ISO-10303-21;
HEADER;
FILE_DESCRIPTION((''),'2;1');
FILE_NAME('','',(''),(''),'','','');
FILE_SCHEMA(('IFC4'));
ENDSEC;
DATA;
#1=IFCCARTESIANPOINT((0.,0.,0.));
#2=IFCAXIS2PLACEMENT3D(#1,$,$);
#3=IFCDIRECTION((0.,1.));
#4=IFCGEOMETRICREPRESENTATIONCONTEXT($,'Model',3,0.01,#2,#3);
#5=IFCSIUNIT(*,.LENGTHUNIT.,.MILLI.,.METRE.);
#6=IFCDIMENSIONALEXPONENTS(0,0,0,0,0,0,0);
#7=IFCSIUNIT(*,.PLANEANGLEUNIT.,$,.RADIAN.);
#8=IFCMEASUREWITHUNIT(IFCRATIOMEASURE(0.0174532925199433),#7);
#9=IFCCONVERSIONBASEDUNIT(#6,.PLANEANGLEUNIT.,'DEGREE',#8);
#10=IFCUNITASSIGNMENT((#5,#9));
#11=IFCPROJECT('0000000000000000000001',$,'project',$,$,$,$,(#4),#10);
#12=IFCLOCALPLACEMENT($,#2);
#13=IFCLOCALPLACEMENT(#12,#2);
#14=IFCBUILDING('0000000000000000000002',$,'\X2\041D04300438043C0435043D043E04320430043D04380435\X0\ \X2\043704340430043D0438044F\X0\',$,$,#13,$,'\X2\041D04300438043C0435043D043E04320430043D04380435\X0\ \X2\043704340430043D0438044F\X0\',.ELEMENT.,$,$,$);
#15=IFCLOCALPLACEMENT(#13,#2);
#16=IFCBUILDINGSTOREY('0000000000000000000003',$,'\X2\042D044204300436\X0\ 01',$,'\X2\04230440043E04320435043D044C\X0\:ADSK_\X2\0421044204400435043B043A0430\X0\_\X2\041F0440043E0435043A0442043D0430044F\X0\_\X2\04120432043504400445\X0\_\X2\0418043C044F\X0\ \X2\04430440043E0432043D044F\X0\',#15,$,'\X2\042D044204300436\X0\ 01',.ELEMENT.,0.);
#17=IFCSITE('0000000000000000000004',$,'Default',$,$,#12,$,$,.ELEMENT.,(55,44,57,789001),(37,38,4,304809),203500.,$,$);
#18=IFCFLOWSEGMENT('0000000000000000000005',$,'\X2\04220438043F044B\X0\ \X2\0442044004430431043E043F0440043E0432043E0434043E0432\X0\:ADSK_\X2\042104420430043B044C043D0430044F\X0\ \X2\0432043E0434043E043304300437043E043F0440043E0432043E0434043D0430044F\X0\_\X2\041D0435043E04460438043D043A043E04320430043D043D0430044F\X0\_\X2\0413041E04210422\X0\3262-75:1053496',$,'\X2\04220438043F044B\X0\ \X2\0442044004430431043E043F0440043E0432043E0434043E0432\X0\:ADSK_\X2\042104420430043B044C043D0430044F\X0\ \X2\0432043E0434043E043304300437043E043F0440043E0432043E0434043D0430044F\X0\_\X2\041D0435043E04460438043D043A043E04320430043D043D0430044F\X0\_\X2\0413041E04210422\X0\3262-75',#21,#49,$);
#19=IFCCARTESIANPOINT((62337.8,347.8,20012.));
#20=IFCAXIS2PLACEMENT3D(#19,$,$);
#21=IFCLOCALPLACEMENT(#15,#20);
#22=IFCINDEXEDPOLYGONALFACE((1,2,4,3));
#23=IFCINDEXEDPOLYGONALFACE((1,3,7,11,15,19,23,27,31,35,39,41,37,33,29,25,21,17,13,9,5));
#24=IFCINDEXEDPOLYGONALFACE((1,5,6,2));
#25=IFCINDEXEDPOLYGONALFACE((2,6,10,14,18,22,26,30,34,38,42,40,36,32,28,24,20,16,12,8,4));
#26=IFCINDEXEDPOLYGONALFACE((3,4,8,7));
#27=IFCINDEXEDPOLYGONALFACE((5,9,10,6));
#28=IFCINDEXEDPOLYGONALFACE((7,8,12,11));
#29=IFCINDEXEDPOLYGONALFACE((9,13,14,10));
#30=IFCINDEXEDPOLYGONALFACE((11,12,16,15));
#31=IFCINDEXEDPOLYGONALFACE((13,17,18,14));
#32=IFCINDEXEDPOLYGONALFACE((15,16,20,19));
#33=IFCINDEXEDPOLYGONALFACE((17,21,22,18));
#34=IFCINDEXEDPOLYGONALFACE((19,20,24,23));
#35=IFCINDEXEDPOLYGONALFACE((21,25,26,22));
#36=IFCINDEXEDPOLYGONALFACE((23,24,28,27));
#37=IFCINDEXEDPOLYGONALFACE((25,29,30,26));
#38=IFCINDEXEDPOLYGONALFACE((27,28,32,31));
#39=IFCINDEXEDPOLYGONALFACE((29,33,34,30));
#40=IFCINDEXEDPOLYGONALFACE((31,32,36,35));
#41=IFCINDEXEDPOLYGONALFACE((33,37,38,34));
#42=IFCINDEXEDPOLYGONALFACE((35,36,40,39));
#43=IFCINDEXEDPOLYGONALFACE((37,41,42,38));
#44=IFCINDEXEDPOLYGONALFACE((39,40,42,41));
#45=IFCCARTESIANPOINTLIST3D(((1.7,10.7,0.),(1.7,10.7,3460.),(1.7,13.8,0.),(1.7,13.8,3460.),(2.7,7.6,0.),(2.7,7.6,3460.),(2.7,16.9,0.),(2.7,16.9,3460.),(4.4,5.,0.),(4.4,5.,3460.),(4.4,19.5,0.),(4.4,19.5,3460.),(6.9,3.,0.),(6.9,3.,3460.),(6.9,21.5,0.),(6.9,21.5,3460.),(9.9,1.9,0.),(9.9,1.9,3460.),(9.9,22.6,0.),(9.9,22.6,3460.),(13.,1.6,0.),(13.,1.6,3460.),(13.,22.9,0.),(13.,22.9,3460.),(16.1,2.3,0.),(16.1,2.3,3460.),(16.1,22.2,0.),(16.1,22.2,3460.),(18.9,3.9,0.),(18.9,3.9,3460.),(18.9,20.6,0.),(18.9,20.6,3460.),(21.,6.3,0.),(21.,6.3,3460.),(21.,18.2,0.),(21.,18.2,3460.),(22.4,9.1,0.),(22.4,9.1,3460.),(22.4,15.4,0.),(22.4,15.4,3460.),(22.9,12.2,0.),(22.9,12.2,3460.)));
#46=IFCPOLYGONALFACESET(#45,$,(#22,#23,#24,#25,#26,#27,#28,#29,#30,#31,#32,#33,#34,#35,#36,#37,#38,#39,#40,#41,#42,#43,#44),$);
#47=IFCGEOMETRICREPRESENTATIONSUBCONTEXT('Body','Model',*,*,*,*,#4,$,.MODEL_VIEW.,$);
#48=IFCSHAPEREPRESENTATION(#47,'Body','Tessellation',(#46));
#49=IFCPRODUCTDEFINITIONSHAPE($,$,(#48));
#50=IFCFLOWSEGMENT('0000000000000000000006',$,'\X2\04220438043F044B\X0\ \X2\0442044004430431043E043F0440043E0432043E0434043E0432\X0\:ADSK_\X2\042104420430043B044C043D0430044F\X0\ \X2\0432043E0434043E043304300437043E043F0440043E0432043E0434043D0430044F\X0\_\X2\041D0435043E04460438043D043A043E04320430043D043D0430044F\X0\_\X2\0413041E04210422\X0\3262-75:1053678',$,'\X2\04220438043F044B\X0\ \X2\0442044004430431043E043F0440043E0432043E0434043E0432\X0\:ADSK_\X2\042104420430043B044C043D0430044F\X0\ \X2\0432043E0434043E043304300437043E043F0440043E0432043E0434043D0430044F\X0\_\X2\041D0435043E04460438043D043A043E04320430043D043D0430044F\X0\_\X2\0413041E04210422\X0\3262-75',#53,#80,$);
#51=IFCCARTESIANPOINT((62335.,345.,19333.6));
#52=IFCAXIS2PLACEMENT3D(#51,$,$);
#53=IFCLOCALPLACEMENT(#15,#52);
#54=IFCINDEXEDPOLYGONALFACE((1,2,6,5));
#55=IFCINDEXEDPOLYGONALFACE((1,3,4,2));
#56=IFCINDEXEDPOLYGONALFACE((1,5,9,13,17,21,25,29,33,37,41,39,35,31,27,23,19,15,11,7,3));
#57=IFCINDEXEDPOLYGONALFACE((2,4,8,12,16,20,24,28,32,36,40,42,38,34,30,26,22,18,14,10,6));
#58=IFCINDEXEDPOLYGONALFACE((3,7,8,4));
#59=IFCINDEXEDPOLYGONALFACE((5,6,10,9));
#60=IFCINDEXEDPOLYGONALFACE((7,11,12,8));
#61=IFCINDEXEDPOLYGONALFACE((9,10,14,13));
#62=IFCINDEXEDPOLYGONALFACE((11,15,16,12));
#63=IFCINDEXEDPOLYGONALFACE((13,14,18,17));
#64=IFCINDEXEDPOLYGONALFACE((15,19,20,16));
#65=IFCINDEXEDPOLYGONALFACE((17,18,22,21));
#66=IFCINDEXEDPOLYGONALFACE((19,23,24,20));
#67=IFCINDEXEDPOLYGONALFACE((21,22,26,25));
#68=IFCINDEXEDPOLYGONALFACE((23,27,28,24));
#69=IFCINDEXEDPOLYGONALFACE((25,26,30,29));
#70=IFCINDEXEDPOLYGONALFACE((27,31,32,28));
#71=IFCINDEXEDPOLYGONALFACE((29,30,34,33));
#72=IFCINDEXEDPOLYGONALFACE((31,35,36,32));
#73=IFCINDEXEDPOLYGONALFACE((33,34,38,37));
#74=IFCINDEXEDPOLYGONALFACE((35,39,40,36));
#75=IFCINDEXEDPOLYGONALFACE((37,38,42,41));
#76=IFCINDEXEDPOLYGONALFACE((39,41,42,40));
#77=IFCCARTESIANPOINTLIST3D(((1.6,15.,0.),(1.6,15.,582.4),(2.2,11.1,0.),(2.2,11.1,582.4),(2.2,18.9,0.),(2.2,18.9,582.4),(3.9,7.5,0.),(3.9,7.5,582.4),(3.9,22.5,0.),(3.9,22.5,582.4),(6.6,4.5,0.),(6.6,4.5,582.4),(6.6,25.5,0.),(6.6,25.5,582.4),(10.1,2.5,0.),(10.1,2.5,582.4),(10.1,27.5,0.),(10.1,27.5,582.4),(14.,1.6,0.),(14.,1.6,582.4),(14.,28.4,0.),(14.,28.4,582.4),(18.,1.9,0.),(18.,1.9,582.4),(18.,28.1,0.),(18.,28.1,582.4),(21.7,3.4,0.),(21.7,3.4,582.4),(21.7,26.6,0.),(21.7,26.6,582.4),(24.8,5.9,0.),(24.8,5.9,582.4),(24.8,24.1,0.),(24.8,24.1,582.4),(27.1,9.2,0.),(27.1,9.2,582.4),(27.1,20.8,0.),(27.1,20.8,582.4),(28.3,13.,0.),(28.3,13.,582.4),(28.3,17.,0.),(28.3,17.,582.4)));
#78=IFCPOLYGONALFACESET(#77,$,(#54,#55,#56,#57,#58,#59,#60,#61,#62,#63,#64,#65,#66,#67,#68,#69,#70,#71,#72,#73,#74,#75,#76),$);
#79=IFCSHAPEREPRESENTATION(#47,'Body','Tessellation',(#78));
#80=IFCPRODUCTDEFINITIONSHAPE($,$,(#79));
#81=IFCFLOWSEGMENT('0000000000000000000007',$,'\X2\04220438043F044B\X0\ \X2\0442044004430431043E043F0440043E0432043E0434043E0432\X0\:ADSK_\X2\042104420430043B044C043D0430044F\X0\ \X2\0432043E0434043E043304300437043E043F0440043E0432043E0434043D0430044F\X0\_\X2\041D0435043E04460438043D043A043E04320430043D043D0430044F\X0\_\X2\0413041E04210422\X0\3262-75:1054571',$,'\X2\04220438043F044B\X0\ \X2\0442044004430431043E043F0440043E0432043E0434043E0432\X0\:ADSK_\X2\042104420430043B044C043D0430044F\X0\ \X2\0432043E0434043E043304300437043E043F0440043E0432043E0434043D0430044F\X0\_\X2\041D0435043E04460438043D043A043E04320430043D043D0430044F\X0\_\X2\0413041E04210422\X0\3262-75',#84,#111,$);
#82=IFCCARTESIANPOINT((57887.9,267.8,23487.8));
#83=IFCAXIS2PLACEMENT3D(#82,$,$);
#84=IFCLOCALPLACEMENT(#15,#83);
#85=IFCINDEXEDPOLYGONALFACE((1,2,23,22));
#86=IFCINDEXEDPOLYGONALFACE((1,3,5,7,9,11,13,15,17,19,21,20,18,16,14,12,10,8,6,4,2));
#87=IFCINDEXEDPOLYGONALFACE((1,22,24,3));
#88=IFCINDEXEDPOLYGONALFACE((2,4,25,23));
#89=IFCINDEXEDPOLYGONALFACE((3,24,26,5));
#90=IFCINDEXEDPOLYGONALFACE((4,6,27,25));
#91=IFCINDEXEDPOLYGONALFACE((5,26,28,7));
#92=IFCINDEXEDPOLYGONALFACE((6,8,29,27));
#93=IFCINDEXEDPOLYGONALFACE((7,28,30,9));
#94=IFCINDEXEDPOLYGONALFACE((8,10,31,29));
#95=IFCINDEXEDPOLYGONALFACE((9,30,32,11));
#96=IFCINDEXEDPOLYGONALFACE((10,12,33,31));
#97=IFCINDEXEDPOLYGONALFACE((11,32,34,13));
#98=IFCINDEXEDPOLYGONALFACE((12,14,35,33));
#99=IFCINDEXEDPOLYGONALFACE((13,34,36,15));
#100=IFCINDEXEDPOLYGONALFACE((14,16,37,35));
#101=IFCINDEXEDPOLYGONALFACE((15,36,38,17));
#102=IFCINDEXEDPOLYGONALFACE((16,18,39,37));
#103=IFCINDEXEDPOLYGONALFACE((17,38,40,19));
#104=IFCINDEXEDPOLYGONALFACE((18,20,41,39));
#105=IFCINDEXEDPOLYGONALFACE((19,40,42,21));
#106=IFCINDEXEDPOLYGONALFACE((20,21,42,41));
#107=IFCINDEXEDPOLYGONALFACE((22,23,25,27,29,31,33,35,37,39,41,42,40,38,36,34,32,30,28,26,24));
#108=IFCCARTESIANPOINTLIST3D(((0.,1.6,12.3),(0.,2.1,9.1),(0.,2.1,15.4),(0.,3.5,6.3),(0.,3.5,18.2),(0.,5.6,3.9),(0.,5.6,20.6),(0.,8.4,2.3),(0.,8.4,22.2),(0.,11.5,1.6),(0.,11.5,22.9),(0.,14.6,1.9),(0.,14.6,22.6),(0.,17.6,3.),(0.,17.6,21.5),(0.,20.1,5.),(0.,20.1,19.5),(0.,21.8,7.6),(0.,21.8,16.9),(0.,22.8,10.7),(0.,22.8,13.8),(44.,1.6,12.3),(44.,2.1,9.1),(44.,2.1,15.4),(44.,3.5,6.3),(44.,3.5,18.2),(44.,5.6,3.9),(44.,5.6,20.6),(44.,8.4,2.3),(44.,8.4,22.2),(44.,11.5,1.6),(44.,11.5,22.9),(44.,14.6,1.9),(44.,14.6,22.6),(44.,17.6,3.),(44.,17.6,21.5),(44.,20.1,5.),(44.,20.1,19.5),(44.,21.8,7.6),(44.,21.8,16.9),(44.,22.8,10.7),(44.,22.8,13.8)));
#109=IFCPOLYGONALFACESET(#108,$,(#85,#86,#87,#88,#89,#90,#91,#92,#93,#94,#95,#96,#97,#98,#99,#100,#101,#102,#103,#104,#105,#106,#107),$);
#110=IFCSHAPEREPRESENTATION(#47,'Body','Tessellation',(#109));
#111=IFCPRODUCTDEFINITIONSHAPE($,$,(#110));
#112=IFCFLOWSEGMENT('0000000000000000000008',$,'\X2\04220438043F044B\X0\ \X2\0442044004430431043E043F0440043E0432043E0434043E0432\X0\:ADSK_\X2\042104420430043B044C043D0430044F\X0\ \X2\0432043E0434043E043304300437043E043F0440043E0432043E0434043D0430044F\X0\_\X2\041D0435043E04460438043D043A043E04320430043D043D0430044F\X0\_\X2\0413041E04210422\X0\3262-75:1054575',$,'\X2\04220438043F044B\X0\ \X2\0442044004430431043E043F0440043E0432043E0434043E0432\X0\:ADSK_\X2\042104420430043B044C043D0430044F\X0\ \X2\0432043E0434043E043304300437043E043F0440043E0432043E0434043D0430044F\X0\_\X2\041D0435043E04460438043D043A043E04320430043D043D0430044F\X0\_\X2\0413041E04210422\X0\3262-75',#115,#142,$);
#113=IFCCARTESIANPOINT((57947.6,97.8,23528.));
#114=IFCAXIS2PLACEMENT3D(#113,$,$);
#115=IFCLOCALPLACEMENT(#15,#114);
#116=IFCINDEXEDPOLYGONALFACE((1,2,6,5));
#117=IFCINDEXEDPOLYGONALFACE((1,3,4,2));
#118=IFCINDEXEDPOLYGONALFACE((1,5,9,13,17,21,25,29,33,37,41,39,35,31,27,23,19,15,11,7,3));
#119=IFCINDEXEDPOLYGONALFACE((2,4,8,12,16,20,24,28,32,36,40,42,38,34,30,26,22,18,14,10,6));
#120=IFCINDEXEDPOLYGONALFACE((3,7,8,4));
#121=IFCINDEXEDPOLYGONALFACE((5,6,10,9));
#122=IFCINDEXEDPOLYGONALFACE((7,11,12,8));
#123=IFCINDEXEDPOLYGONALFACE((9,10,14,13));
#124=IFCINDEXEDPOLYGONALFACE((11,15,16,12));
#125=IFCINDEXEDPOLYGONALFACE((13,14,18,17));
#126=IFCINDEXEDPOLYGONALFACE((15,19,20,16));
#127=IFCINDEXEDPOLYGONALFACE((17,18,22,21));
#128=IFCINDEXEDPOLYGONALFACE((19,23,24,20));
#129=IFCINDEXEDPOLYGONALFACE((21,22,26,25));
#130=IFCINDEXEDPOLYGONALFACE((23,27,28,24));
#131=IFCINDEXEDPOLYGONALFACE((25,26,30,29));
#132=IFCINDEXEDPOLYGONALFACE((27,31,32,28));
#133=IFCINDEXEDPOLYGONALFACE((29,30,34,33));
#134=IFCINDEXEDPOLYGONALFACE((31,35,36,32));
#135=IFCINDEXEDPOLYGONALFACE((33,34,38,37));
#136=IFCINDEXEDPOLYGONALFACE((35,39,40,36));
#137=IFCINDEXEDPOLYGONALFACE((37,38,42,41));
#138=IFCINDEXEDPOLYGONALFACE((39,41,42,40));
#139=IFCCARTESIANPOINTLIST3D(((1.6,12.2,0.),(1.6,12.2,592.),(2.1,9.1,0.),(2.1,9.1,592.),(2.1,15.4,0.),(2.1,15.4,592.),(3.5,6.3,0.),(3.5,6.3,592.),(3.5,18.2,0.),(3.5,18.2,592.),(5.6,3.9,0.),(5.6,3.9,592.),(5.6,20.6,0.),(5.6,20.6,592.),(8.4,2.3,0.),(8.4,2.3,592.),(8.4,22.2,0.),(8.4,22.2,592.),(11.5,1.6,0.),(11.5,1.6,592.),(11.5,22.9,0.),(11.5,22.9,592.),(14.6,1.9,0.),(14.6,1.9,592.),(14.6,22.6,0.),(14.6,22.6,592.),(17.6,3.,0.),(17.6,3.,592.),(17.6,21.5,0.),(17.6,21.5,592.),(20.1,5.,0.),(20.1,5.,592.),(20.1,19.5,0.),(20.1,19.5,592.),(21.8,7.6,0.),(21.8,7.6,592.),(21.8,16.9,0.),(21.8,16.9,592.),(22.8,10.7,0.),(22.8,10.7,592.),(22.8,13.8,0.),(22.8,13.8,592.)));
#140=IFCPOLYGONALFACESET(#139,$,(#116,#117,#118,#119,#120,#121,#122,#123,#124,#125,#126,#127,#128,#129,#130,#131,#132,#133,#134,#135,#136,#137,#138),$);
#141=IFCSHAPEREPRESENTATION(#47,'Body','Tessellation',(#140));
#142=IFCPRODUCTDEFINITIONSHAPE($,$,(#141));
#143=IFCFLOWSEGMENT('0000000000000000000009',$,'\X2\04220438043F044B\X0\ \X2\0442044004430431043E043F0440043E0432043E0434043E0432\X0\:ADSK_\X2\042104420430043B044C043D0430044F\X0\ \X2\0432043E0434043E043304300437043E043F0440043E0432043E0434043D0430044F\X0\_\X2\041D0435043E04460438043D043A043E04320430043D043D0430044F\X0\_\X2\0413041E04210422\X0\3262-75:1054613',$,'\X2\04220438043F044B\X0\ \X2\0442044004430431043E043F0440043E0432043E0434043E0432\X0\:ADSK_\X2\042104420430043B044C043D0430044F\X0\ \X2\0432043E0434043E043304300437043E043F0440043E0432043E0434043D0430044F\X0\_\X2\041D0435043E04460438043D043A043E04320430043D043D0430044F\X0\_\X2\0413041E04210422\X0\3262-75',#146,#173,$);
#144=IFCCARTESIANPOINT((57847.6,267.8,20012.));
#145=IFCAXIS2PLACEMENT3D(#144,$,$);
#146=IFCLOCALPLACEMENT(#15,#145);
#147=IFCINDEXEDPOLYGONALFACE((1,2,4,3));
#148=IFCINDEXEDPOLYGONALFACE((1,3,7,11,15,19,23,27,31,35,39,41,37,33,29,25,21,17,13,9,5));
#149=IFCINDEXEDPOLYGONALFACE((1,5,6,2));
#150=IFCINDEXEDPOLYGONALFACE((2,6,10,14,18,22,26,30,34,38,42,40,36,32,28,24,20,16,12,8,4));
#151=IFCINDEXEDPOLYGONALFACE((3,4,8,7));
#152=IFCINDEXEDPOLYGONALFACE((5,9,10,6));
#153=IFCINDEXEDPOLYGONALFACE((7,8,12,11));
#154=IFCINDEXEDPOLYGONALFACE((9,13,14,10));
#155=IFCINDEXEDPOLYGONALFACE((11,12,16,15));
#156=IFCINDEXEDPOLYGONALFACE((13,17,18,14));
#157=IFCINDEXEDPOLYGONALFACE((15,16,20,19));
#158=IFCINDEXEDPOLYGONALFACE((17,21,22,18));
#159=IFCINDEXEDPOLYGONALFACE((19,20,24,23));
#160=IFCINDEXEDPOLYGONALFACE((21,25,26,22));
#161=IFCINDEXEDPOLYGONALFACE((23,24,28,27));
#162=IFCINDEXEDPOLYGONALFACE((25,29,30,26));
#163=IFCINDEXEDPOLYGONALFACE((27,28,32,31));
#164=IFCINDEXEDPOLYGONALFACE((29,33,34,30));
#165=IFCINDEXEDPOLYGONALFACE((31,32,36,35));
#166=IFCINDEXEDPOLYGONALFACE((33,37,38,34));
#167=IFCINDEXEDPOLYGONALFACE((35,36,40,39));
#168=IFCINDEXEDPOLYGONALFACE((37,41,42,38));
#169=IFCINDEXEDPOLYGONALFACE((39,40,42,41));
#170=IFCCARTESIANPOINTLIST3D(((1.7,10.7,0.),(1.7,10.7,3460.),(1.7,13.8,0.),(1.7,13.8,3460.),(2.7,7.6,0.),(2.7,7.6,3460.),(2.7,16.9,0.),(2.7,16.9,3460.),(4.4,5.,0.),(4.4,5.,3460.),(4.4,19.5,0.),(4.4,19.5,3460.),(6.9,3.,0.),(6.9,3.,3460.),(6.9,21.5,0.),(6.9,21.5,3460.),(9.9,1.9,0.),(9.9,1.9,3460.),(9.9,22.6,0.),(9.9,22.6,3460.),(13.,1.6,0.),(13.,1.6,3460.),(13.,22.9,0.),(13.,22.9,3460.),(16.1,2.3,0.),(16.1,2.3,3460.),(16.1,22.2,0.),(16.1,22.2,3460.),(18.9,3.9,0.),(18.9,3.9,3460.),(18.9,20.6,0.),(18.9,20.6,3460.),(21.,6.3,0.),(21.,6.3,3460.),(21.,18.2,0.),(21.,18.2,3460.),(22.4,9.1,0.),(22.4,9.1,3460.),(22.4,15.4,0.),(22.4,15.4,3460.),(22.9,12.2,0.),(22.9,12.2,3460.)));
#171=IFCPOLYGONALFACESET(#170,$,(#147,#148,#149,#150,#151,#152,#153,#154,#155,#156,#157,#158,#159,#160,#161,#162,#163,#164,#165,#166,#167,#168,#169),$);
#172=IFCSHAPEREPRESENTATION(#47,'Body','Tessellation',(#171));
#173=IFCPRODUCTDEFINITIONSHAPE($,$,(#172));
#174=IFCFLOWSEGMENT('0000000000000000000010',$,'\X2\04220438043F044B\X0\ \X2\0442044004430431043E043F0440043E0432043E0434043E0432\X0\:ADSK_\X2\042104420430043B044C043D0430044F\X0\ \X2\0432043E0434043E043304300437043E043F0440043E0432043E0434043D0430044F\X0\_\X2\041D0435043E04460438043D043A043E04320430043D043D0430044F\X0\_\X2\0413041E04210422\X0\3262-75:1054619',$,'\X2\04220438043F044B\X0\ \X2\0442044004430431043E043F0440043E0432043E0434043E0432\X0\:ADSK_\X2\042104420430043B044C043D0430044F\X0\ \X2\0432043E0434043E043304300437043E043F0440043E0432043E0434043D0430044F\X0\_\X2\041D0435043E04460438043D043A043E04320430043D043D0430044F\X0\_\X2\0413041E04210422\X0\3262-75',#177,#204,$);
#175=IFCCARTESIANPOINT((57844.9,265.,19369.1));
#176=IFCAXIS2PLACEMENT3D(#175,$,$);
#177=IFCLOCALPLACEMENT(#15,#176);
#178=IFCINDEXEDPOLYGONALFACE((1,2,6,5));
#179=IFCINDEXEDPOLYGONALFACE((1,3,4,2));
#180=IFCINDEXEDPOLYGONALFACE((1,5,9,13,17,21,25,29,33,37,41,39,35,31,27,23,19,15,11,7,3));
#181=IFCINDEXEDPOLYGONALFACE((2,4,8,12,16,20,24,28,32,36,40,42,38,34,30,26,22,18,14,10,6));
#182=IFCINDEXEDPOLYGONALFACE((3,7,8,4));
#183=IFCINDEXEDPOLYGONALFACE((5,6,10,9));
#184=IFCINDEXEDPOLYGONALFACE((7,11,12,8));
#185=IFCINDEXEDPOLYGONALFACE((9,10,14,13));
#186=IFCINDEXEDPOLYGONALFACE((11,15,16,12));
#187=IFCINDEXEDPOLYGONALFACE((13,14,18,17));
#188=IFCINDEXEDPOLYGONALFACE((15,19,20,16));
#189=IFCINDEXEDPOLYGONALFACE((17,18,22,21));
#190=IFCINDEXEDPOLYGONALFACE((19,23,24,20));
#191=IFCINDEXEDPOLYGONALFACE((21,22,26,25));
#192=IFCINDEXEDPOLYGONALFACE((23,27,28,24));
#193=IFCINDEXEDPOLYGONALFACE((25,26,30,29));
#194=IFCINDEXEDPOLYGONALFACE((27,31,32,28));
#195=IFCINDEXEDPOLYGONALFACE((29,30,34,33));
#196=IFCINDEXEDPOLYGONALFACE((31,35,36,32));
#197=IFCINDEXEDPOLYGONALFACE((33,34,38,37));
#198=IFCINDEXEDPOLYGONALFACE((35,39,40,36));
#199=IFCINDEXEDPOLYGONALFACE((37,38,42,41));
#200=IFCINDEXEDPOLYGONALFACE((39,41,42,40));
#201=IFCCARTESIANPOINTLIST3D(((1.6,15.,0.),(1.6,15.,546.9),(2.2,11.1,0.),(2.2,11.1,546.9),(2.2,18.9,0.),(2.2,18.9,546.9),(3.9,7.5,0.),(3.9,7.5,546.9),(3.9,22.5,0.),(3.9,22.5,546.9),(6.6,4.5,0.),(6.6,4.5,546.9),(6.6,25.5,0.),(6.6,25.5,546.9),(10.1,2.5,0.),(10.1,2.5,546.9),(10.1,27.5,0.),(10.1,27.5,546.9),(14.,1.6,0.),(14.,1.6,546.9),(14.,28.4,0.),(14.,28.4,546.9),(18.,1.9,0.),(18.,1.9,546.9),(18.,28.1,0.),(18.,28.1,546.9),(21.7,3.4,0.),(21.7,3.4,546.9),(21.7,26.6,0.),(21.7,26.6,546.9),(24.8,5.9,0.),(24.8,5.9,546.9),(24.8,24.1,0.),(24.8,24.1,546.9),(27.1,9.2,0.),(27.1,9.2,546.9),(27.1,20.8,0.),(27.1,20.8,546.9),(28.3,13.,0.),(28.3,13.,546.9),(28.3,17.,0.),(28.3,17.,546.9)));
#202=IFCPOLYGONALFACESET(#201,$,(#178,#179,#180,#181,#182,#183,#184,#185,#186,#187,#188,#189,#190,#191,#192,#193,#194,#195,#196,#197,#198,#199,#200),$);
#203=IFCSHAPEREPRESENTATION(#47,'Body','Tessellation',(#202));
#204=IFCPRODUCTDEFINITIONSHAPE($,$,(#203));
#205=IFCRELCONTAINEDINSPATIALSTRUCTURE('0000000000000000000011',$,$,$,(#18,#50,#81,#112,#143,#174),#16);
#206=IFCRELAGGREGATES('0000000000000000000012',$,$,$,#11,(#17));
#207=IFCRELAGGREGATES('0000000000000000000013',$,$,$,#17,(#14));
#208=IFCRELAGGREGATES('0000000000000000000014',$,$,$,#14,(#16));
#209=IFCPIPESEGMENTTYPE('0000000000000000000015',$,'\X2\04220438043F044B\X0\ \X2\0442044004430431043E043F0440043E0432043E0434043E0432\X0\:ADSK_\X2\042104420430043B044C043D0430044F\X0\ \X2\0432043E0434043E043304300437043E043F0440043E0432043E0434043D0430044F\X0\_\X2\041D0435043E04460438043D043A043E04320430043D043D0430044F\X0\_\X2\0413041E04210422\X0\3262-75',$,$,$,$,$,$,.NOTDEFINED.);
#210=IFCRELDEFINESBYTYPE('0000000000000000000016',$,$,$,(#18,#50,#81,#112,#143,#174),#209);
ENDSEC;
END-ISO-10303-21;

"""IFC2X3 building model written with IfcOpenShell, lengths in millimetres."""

from ifc_helpers import new_model, entity, si_unit, converted_unit, direction, frame, origin, origin_2d_with_axis, place, context, subcontext, project, spatial, circle, extrude, type_object, element, save


model = new_model("IFC2X3")

# Units and contexts
model_context = context("Model", 3, precision=0.01, world=origin(), true_north=direction((0.0, 1.0)))
body_context = subcontext(model_context, "Body", "Model", "MODEL_VIEW")
ifc_project = project(units=[si_unit("LENGTHUNIT", "METRE", prefix="MILLI"), converted_unit("PLANEANGLEUNIT", "DEGREE", entity("IfcRatioMeasure", 0.0174532925199433), si_unit("PLANEANGLEUNIT", "RADIAN"), dimensions=[0, 0, 0, 0, 0, 0, 0])], contexts=[model_context])

# Site, building, storey
site_placement = place(None, origin())
site = spatial("IfcSite", under=ifc_project, at=site_placement, Name="Default", CompositionType="ELEMENT", RefLatitude=(55, 44, 57, 789001), RefLongitude=(37, 38, 4, 304809), RefElevation=203500.0)
building_placement = place(site_placement, origin())
building = spatial("IfcBuilding", under=site, at=building_placement, Name="Наименование здания", LongName="Наименование здания", CompositionType="ELEMENT")
storey_placement = place(building_placement, origin())
storey = spatial("IfcBuildingStorey", under=building, at=storey_placement, Name="Этаж 01", ObjectType="Уровень:ADSK_Стрелка_Проектная_Вверх_Имя уровня", LongName="Этаж 01", CompositionType="ELEMENT", Elevation=0.0)

# Flow segments
pipe_segment_type = type_object("IfcPipeSegmentType", Name="Типы трубопроводов:ADSK_Стальная водогазопроводная_Неоцинкованная_ГОСТ3262-75", PredefinedType="NOTDEFINED")
flow_segment_1_placement = place(storey_placement, frame((62337.8, 347.8, 20012.0)))
element("IfcFlowSegment", 1, at=flow_segment_1_placement, inside=storey, type_object=pipe_segment_type, Name="Типы трубопроводов:ADSK_Стальная водогазопроводная_Неоцинкованная_ГОСТ3262-75:1053496", ObjectType="Типы трубопроводов:ADSK_Стальная водогазопроводная_Неоцинкованная_ГОСТ3262-75", context=body_context, shape_type="SweptSolid", body=[
    extrude(circle(Radius=10.7, at=origin_2d_with_axis()), frame((12.2, 12.2, 0.0)), (0.0, 0.0, 1.0), 3460.0),
])
flow_segment_2_placement = place(storey_placement, frame((62335.0, 345.0, 19333.6)))
element("IfcFlowSegment", 2, at=flow_segment_2_placement, inside=storey, type_object=pipe_segment_type, Name="Типы трубопроводов:ADSK_Стальная водогазопроводная_Неоцинкованная_ГОСТ3262-75:1053678", ObjectType="Типы трубопроводов:ADSK_Стальная водогазопроводная_Неоцинкованная_ГОСТ3262-75", context=body_context, shape_type="SweptSolid", body=[
    extrude(circle(Radius=13.4, at=origin_2d_with_axis()), frame((15.0, 15.0, 0.0), z_axis=(0.0, 0.0, 1.0), x_axis=(-1.0, 0.0, 0.0)), (0.0, 0.0, 1.0), 582.4),
])
flow_segment_3_placement = place(storey_placement, frame((57887.9, 267.8, 23487.8)))
element("IfcFlowSegment", 3, at=flow_segment_3_placement, inside=storey, type_object=pipe_segment_type, Name="Типы трубопроводов:ADSK_Стальная водогазопроводная_Неоцинкованная_ГОСТ3262-75:1054571", ObjectType="Типы трубопроводов:ADSK_Стальная водогазопроводная_Неоцинкованная_ГОСТ3262-75", context=body_context, shape_type="SweptSolid", body=[
    extrude(circle(Radius=10.7, at=origin_2d_with_axis()), frame((0.0, 12.2, 12.2), z_axis=(1.0, 0.0, 0.0), x_axis=(0.0, -1.0, 0.0)), (0.0, 0.0, 1.0), 44.0),
])
flow_segment_4_placement = place(storey_placement, frame((57947.6, 97.8, 23528.0)))
element("IfcFlowSegment", 4, at=flow_segment_4_placement, inside=storey, type_object=pipe_segment_type, Name="Типы трубопроводов:ADSK_Стальная водогазопроводная_Неоцинкованная_ГОСТ3262-75:1054575", ObjectType="Типы трубопроводов:ADSK_Стальная водогазопроводная_Неоцинкованная_ГОСТ3262-75", context=body_context, shape_type="SweptSolid", body=[
    extrude(circle(Radius=10.7, at=origin_2d_with_axis()), frame((12.2, 12.2, 0.0), z_axis=(0.0, 0.0, 1.0), x_axis=(-1.0, 0.0, 0.0)), (0.0, 0.0, 1.0), 592.0),
])
flow_segment_5_placement = place(storey_placement, frame((57847.6, 267.8, 20012.0)))
element("IfcFlowSegment", 5, at=flow_segment_5_placement, inside=storey, type_object=pipe_segment_type, Name="Типы трубопроводов:ADSK_Стальная водогазопроводная_Неоцинкованная_ГОСТ3262-75:1054613", ObjectType="Типы трубопроводов:ADSK_Стальная водогазопроводная_Неоцинкованная_ГОСТ3262-75", context=body_context, shape_type="SweptSolid", body=[
    extrude(circle(Radius=10.7, at=origin_2d_with_axis()), frame((12.2, 12.2, 0.0)), (0.0, 0.0, 1.0), 3460.0),
])
flow_segment_6_placement = place(storey_placement, frame((57844.9, 265.0, 19369.1)))
element("IfcFlowSegment", 6, at=flow_segment_6_placement, inside=storey, type_object=pipe_segment_type, Name="Типы трубопроводов:ADSK_Стальная водогазопроводная_Неоцинкованная_ГОСТ3262-75:1054619", ObjectType="Типы трубопроводов:ADSK_Стальная водогазопроводная_Неоцинкованная_ГОСТ3262-75", context=body_context, shape_type="SweptSolid", body=[
    extrude(circle(Radius=13.4, at=origin_2d_with_axis()), frame((15.0, 15.0, 0.0), z_axis=(0.0, 0.0, 1.0), x_axis=(-1.0, 0.0, 0.0)), (0.0, 0.0, 1.0), 546.9),
])

save(model, "model.ifc")
